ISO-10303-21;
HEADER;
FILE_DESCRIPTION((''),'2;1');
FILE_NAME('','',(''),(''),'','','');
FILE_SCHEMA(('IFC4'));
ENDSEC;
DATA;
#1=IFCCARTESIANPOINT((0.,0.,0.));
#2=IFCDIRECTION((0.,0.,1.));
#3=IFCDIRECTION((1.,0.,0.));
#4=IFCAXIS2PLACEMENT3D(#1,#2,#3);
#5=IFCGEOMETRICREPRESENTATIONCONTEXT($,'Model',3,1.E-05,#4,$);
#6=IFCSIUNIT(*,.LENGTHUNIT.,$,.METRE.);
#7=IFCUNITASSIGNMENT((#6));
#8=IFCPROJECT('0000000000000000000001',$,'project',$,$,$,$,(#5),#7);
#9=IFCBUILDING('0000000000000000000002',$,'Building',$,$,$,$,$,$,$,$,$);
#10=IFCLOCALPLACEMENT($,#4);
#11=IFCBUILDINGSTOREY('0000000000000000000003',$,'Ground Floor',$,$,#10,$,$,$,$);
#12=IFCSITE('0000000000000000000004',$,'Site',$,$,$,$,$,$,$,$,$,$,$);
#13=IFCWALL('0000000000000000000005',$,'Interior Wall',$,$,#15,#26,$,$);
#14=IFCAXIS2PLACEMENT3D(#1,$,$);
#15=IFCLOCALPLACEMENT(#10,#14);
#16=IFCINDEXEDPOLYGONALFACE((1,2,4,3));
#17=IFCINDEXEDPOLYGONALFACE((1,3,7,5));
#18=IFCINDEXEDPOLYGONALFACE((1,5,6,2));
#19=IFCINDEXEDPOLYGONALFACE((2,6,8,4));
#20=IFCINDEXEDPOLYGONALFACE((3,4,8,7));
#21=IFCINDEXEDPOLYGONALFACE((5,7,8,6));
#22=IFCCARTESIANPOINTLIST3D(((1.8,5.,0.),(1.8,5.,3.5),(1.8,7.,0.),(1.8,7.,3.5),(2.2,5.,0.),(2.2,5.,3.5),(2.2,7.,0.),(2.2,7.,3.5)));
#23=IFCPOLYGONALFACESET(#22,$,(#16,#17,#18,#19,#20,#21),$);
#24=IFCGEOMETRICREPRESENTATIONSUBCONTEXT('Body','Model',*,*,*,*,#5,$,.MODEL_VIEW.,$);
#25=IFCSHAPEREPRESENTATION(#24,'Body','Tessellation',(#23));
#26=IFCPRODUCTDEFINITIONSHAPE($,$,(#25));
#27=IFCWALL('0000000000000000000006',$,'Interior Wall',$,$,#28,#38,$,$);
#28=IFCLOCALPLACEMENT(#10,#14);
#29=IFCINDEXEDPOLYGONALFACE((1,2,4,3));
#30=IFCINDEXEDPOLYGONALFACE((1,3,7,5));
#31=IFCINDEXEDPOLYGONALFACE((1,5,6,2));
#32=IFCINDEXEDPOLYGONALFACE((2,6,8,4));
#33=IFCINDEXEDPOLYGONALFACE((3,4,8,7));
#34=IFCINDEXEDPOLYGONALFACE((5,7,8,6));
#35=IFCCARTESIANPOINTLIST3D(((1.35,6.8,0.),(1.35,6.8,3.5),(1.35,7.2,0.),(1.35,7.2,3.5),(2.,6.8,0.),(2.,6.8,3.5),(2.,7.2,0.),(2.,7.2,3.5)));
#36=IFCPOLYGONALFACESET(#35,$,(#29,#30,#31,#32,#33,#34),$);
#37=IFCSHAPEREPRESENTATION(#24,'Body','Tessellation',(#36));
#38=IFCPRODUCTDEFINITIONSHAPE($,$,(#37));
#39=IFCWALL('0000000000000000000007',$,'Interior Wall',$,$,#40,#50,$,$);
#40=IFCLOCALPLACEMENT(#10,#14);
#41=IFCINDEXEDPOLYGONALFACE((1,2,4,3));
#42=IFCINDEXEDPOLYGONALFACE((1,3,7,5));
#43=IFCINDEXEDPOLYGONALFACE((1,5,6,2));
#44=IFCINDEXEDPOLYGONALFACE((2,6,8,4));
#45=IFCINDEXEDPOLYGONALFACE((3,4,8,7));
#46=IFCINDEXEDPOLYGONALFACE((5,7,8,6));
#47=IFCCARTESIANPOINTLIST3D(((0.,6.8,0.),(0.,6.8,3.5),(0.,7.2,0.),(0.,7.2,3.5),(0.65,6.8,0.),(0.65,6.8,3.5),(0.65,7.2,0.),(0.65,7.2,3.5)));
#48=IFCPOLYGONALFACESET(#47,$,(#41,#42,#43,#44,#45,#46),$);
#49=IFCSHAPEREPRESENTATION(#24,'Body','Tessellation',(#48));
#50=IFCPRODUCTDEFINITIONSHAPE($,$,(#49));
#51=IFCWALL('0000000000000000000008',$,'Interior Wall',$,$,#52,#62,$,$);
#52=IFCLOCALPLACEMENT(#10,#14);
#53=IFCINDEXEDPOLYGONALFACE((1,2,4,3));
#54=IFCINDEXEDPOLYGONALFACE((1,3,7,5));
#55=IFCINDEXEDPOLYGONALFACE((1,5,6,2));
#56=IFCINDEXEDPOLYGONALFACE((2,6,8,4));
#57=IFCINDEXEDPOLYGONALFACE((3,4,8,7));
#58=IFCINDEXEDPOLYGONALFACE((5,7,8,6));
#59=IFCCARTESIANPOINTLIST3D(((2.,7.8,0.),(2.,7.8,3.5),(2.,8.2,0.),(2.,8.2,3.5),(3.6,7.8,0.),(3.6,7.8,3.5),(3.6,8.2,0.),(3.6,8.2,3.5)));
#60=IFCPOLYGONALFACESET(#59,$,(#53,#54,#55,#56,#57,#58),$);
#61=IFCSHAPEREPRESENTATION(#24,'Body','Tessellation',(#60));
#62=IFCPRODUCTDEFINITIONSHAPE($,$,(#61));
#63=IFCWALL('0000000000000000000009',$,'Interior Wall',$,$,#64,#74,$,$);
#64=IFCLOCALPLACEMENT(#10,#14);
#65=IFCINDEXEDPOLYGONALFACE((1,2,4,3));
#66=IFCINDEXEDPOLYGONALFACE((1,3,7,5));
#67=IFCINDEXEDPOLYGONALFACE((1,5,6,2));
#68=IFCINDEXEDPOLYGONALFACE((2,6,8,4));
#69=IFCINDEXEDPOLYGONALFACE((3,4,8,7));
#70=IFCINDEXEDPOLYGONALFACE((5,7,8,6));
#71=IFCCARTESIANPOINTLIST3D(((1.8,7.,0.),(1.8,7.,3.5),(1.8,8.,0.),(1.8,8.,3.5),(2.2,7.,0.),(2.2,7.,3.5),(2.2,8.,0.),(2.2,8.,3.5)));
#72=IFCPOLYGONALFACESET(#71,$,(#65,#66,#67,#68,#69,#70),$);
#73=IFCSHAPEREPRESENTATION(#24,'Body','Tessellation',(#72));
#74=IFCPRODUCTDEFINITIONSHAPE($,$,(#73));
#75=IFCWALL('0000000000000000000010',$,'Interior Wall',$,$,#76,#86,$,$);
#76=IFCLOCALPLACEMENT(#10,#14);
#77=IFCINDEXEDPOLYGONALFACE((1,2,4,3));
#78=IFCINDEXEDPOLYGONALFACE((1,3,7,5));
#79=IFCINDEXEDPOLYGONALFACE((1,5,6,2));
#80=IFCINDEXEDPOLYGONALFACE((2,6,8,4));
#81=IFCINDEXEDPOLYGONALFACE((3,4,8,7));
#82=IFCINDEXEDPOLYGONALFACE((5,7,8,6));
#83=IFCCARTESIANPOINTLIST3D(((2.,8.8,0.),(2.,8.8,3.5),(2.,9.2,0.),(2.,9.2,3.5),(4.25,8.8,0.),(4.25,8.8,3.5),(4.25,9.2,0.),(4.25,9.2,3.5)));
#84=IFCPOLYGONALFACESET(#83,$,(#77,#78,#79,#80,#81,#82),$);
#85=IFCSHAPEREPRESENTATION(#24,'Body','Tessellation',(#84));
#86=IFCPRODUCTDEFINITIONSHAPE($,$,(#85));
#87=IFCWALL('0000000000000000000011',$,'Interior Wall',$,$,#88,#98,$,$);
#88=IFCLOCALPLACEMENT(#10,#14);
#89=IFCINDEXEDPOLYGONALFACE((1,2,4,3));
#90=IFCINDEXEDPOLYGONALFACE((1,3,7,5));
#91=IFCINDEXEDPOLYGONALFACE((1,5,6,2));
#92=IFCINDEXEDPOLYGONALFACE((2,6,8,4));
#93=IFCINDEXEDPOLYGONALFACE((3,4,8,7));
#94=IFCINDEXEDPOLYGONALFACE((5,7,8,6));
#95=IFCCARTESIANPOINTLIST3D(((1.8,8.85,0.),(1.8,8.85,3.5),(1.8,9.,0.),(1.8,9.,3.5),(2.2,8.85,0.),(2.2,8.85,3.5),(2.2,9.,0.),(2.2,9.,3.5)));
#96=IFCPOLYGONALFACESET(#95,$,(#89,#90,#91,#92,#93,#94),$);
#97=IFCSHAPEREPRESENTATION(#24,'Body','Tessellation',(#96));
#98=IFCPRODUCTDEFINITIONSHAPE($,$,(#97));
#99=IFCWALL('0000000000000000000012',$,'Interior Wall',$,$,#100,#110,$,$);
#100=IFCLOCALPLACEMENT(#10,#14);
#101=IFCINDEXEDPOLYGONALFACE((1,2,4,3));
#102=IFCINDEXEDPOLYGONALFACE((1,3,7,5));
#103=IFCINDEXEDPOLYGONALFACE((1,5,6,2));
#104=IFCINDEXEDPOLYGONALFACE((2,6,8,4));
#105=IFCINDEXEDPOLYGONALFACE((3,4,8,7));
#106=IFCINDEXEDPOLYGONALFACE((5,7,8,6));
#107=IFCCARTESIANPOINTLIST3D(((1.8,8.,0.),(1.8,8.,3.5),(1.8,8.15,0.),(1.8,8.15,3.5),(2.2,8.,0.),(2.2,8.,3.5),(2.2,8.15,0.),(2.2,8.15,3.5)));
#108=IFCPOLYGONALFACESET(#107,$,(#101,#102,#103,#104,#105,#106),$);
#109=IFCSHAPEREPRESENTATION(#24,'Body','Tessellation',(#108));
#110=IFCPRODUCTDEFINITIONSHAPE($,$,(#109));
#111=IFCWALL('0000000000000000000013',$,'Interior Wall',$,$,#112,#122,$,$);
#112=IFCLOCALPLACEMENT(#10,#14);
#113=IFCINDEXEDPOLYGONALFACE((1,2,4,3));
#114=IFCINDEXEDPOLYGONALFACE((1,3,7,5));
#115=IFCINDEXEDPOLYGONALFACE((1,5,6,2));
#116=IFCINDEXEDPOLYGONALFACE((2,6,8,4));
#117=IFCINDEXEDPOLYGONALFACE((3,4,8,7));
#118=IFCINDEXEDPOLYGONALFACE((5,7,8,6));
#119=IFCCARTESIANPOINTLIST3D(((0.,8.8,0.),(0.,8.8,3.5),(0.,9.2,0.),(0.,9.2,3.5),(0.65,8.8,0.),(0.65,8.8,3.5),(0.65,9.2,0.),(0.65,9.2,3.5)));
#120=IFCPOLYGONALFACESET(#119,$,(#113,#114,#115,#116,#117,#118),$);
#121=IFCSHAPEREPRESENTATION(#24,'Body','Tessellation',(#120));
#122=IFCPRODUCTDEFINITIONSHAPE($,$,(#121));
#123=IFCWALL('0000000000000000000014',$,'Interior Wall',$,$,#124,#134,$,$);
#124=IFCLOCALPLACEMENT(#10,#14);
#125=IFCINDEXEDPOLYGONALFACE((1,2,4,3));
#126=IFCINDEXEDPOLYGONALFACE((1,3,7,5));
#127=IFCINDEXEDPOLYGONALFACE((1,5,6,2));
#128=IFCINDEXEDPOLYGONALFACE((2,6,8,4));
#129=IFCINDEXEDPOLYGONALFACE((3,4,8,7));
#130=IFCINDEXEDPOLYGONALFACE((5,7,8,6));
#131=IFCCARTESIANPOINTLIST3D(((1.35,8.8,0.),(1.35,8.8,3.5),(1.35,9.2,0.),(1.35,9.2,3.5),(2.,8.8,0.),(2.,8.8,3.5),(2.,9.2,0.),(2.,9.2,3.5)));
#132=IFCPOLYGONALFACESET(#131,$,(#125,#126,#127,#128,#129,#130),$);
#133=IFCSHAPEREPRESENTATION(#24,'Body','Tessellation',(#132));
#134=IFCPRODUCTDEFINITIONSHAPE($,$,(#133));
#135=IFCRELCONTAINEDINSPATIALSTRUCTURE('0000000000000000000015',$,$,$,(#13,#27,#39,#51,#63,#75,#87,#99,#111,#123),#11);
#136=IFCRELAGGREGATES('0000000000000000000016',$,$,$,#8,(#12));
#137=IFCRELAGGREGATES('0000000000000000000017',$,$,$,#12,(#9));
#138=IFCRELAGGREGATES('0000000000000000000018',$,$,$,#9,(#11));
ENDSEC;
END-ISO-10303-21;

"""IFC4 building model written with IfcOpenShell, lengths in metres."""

from ifc_helpers import new_model, si_unit, frame, origin_with_axes, place, context, subcontext, project, spatial, indexed_curve, outline, extrude, element, save


model = new_model("IFC4")

# Units and contexts
model_context = context("Model", 3, precision=1e-05, world=origin_with_axes())
body_context = subcontext(model_context, "Body", "Model", "MODEL_VIEW")
ifc_project = project(units=[si_unit("LENGTHUNIT", "METRE")], contexts=[model_context])

# Site, building, storey
site = spatial("IfcSite", under=ifc_project, Name="Site")
building = spatial("IfcBuilding", under=site, Name="Building")
storey_placement = place(None, origin_with_axes())
storey = spatial("IfcBuildingStorey", under=building, at=storey_placement, Name="Ground Floor")

# Walls
wall_1_placement = place(storey_placement, frame((2.0, 5.0, 0.0), z_axis=(0.0, 0.0, 1.0), x_axis=(0.0, 1.0, 0.0)))
element("IfcWall", 1, at=wall_1_placement, inside=storey, Name="Interior Wall", context=body_context, shape_type="SweptSolid", body=[
    extrude(outline(indexed_curve([(0.0, 0.0), (0.0, 0.4), (2.0, 0.4), (2.0, 0.0), (0.0, 0.0)], self_intersect=False)), frame((0.0, -0.2, 0.0), z_axis=(0.0, 0.0, 1.0), x_axis=(1.0, 0.0, 0.0)), (0.0, 0.0, 1.0), 3.5),
])
for number, where, z_axis, x_axis, name in (
    (2, (2.0, 7.0, 0.0), (0.0, 0.0, 1.0), (-1.0, 0.0, 0.0), "Interior Wall"),
    (3, (0.65, 7.0, 0.0), (0.0, 0.0, 1.0), (-1.0, 0.0, 0.0), "Interior Wall"),
):
    element("IfcWall", number, at=place(storey_placement, frame(where, z_axis=z_axis, x_axis=x_axis)), inside=storey, Name=name, context=body_context, shape_type="SweptSolid", body=[
        extrude(outline(indexed_curve([(0.0, 0.0), (0.0, 0.4), (0.65, 0.4), (0.65, 0.0), (0.0, 0.0)], self_intersect=False)), frame((0.0, -0.2, 0.0), z_axis=(0.0, 0.0, 1.0), x_axis=(1.0, 0.0, 0.0)), (0.0, 0.0, 1.0), 3.5),
    ])
wall_2_placement = place(storey_placement, frame((3.6, 8.0, 0.0), z_axis=(0.0, 0.0, 1.0), x_axis=(-1.0, 0.0, 0.0)))
element("IfcWall", 4, at=wall_2_placement, inside=storey, Name="Interior Wall", context=body_context, shape_type="SweptSolid", body=[
    extrude(outline(indexed_curve([(0.0, 0.0), (0.0, 0.4), (1.6, 0.4), (1.6, 0.0), (0.0, 0.0)], self_intersect=False)), frame((0.0, -0.2, 0.0), z_axis=(0.0, 0.0, 1.0), x_axis=(1.0, 0.0, 0.0)), (0.0, 0.0, 1.0), 3.5),
])
wall_3_placement = place(storey_placement, frame((2.0, 8.0, 0.0), z_axis=(0.0, 0.0, 1.0), x_axis=(0.0, -1.0, 0.0)))
element("IfcWall", 5, at=wall_3_placement, inside=storey, Name="Interior Wall", context=body_context, shape_type="SweptSolid", body=[
    extrude(outline(indexed_curve([(0.0, 0.0), (0.0, 0.4), (1.0, 0.4), (1.0, 0.0), (0.0, 0.0)], self_intersect=False)), frame((0.0, -0.2, 0.0), z_axis=(0.0, 0.0, 1.0), x_axis=(1.0, 0.0, 0.0)), (0.0, 0.0, 1.0), 3.5),
])
wall_4_placement = place(storey_placement, frame((4.25, 9.0, 0.0), z_axis=(0.0, 0.0, 1.0), x_axis=(-1.0, 0.0, 0.0)))
element("IfcWall", 6, at=wall_4_placement, inside=storey, Name="Interior Wall", context=body_context, shape_type="SweptSolid", body=[
    extrude(outline(indexed_curve([(0.0, 0.0), (0.0, 0.4), (2.25, 0.4), (2.25, 0.0), (0.0, 0.0)], self_intersect=False)), frame((0.0, -0.2, 0.0), z_axis=(0.0, 0.0, 1.0), x_axis=(1.0, 0.0, 0.0)), (0.0, 0.0, 1.0), 3.5),
])
for number, where, z_axis, x_axis, name in (
    (7, (2.0, 9.0, 0.0), (0.0, 0.0, 1.0), (0.0, -1.0, 0.0), "Interior Wall"),
    (8, (2.0, 8.15, 0.0), (0.0, 0.0, 1.0), (0.0, -1.0, 0.0), "Interior Wall"),
):
    element("IfcWall", number, at=place(storey_placement, frame(where, z_axis=z_axis, x_axis=x_axis)), inside=storey, Name=name, context=body_context, shape_type="SweptSolid", body=[
        extrude(outline(indexed_curve([(0.0, 0.0), (0.0, 0.4), (0.15, 0.4), (0.15, 0.0), (0.0, 0.0)], self_intersect=False)), frame((0.0, -0.2, 0.0), z_axis=(0.0, 0.0, 1.0), x_axis=(1.0, 0.0, 0.0)), (0.0, 0.0, 1.0), 3.5),
    ])
wall_5_placement = place(storey_placement, frame((0.0, 9.0, 0.0), z_axis=(0.0, 0.0, 1.0), x_axis=(1.0, 0.0, 0.0)))
element("IfcWall", 9, at=wall_5_placement, inside=storey, Name="Interior Wall", context=body_context, shape_type="SweptSolid", body=[
    extrude(outline(indexed_curve([(0.0, 0.0), (0.0, 0.4), (0.65, 0.4), (0.65, 0.0), (0.0, 0.0)], self_intersect=False)), frame((0.0, -0.2, 0.0), z_axis=(0.0, 0.0, 1.0), x_axis=(1.0, 0.0, 0.0)), (0.0, 0.0, 1.0), 3.5),
])
wall_6_placement = place(storey_placement, frame((1.35, 9.0, 0.0), z_axis=(0.0, 0.0, 1.0), x_axis=(1.0, 0.0, 0.0)))
element("IfcWall", 10, at=wall_6_placement, inside=storey, Name="Interior Wall", context=body_context, shape_type="SweptSolid", body=[
    extrude(outline(indexed_curve([(0.0, 0.0), (0.0, 0.4), (0.65, 0.4), (0.65, 0.0), (0.0, 0.0)], self_intersect=False)), frame((0.0, -0.2, 0.0), z_axis=(0.0, 0.0, 1.0), x_axis=(1.0, 0.0, 0.0)), (0.0, 0.0, 1.0), 3.5),
])

save(model, "model.ifc")
